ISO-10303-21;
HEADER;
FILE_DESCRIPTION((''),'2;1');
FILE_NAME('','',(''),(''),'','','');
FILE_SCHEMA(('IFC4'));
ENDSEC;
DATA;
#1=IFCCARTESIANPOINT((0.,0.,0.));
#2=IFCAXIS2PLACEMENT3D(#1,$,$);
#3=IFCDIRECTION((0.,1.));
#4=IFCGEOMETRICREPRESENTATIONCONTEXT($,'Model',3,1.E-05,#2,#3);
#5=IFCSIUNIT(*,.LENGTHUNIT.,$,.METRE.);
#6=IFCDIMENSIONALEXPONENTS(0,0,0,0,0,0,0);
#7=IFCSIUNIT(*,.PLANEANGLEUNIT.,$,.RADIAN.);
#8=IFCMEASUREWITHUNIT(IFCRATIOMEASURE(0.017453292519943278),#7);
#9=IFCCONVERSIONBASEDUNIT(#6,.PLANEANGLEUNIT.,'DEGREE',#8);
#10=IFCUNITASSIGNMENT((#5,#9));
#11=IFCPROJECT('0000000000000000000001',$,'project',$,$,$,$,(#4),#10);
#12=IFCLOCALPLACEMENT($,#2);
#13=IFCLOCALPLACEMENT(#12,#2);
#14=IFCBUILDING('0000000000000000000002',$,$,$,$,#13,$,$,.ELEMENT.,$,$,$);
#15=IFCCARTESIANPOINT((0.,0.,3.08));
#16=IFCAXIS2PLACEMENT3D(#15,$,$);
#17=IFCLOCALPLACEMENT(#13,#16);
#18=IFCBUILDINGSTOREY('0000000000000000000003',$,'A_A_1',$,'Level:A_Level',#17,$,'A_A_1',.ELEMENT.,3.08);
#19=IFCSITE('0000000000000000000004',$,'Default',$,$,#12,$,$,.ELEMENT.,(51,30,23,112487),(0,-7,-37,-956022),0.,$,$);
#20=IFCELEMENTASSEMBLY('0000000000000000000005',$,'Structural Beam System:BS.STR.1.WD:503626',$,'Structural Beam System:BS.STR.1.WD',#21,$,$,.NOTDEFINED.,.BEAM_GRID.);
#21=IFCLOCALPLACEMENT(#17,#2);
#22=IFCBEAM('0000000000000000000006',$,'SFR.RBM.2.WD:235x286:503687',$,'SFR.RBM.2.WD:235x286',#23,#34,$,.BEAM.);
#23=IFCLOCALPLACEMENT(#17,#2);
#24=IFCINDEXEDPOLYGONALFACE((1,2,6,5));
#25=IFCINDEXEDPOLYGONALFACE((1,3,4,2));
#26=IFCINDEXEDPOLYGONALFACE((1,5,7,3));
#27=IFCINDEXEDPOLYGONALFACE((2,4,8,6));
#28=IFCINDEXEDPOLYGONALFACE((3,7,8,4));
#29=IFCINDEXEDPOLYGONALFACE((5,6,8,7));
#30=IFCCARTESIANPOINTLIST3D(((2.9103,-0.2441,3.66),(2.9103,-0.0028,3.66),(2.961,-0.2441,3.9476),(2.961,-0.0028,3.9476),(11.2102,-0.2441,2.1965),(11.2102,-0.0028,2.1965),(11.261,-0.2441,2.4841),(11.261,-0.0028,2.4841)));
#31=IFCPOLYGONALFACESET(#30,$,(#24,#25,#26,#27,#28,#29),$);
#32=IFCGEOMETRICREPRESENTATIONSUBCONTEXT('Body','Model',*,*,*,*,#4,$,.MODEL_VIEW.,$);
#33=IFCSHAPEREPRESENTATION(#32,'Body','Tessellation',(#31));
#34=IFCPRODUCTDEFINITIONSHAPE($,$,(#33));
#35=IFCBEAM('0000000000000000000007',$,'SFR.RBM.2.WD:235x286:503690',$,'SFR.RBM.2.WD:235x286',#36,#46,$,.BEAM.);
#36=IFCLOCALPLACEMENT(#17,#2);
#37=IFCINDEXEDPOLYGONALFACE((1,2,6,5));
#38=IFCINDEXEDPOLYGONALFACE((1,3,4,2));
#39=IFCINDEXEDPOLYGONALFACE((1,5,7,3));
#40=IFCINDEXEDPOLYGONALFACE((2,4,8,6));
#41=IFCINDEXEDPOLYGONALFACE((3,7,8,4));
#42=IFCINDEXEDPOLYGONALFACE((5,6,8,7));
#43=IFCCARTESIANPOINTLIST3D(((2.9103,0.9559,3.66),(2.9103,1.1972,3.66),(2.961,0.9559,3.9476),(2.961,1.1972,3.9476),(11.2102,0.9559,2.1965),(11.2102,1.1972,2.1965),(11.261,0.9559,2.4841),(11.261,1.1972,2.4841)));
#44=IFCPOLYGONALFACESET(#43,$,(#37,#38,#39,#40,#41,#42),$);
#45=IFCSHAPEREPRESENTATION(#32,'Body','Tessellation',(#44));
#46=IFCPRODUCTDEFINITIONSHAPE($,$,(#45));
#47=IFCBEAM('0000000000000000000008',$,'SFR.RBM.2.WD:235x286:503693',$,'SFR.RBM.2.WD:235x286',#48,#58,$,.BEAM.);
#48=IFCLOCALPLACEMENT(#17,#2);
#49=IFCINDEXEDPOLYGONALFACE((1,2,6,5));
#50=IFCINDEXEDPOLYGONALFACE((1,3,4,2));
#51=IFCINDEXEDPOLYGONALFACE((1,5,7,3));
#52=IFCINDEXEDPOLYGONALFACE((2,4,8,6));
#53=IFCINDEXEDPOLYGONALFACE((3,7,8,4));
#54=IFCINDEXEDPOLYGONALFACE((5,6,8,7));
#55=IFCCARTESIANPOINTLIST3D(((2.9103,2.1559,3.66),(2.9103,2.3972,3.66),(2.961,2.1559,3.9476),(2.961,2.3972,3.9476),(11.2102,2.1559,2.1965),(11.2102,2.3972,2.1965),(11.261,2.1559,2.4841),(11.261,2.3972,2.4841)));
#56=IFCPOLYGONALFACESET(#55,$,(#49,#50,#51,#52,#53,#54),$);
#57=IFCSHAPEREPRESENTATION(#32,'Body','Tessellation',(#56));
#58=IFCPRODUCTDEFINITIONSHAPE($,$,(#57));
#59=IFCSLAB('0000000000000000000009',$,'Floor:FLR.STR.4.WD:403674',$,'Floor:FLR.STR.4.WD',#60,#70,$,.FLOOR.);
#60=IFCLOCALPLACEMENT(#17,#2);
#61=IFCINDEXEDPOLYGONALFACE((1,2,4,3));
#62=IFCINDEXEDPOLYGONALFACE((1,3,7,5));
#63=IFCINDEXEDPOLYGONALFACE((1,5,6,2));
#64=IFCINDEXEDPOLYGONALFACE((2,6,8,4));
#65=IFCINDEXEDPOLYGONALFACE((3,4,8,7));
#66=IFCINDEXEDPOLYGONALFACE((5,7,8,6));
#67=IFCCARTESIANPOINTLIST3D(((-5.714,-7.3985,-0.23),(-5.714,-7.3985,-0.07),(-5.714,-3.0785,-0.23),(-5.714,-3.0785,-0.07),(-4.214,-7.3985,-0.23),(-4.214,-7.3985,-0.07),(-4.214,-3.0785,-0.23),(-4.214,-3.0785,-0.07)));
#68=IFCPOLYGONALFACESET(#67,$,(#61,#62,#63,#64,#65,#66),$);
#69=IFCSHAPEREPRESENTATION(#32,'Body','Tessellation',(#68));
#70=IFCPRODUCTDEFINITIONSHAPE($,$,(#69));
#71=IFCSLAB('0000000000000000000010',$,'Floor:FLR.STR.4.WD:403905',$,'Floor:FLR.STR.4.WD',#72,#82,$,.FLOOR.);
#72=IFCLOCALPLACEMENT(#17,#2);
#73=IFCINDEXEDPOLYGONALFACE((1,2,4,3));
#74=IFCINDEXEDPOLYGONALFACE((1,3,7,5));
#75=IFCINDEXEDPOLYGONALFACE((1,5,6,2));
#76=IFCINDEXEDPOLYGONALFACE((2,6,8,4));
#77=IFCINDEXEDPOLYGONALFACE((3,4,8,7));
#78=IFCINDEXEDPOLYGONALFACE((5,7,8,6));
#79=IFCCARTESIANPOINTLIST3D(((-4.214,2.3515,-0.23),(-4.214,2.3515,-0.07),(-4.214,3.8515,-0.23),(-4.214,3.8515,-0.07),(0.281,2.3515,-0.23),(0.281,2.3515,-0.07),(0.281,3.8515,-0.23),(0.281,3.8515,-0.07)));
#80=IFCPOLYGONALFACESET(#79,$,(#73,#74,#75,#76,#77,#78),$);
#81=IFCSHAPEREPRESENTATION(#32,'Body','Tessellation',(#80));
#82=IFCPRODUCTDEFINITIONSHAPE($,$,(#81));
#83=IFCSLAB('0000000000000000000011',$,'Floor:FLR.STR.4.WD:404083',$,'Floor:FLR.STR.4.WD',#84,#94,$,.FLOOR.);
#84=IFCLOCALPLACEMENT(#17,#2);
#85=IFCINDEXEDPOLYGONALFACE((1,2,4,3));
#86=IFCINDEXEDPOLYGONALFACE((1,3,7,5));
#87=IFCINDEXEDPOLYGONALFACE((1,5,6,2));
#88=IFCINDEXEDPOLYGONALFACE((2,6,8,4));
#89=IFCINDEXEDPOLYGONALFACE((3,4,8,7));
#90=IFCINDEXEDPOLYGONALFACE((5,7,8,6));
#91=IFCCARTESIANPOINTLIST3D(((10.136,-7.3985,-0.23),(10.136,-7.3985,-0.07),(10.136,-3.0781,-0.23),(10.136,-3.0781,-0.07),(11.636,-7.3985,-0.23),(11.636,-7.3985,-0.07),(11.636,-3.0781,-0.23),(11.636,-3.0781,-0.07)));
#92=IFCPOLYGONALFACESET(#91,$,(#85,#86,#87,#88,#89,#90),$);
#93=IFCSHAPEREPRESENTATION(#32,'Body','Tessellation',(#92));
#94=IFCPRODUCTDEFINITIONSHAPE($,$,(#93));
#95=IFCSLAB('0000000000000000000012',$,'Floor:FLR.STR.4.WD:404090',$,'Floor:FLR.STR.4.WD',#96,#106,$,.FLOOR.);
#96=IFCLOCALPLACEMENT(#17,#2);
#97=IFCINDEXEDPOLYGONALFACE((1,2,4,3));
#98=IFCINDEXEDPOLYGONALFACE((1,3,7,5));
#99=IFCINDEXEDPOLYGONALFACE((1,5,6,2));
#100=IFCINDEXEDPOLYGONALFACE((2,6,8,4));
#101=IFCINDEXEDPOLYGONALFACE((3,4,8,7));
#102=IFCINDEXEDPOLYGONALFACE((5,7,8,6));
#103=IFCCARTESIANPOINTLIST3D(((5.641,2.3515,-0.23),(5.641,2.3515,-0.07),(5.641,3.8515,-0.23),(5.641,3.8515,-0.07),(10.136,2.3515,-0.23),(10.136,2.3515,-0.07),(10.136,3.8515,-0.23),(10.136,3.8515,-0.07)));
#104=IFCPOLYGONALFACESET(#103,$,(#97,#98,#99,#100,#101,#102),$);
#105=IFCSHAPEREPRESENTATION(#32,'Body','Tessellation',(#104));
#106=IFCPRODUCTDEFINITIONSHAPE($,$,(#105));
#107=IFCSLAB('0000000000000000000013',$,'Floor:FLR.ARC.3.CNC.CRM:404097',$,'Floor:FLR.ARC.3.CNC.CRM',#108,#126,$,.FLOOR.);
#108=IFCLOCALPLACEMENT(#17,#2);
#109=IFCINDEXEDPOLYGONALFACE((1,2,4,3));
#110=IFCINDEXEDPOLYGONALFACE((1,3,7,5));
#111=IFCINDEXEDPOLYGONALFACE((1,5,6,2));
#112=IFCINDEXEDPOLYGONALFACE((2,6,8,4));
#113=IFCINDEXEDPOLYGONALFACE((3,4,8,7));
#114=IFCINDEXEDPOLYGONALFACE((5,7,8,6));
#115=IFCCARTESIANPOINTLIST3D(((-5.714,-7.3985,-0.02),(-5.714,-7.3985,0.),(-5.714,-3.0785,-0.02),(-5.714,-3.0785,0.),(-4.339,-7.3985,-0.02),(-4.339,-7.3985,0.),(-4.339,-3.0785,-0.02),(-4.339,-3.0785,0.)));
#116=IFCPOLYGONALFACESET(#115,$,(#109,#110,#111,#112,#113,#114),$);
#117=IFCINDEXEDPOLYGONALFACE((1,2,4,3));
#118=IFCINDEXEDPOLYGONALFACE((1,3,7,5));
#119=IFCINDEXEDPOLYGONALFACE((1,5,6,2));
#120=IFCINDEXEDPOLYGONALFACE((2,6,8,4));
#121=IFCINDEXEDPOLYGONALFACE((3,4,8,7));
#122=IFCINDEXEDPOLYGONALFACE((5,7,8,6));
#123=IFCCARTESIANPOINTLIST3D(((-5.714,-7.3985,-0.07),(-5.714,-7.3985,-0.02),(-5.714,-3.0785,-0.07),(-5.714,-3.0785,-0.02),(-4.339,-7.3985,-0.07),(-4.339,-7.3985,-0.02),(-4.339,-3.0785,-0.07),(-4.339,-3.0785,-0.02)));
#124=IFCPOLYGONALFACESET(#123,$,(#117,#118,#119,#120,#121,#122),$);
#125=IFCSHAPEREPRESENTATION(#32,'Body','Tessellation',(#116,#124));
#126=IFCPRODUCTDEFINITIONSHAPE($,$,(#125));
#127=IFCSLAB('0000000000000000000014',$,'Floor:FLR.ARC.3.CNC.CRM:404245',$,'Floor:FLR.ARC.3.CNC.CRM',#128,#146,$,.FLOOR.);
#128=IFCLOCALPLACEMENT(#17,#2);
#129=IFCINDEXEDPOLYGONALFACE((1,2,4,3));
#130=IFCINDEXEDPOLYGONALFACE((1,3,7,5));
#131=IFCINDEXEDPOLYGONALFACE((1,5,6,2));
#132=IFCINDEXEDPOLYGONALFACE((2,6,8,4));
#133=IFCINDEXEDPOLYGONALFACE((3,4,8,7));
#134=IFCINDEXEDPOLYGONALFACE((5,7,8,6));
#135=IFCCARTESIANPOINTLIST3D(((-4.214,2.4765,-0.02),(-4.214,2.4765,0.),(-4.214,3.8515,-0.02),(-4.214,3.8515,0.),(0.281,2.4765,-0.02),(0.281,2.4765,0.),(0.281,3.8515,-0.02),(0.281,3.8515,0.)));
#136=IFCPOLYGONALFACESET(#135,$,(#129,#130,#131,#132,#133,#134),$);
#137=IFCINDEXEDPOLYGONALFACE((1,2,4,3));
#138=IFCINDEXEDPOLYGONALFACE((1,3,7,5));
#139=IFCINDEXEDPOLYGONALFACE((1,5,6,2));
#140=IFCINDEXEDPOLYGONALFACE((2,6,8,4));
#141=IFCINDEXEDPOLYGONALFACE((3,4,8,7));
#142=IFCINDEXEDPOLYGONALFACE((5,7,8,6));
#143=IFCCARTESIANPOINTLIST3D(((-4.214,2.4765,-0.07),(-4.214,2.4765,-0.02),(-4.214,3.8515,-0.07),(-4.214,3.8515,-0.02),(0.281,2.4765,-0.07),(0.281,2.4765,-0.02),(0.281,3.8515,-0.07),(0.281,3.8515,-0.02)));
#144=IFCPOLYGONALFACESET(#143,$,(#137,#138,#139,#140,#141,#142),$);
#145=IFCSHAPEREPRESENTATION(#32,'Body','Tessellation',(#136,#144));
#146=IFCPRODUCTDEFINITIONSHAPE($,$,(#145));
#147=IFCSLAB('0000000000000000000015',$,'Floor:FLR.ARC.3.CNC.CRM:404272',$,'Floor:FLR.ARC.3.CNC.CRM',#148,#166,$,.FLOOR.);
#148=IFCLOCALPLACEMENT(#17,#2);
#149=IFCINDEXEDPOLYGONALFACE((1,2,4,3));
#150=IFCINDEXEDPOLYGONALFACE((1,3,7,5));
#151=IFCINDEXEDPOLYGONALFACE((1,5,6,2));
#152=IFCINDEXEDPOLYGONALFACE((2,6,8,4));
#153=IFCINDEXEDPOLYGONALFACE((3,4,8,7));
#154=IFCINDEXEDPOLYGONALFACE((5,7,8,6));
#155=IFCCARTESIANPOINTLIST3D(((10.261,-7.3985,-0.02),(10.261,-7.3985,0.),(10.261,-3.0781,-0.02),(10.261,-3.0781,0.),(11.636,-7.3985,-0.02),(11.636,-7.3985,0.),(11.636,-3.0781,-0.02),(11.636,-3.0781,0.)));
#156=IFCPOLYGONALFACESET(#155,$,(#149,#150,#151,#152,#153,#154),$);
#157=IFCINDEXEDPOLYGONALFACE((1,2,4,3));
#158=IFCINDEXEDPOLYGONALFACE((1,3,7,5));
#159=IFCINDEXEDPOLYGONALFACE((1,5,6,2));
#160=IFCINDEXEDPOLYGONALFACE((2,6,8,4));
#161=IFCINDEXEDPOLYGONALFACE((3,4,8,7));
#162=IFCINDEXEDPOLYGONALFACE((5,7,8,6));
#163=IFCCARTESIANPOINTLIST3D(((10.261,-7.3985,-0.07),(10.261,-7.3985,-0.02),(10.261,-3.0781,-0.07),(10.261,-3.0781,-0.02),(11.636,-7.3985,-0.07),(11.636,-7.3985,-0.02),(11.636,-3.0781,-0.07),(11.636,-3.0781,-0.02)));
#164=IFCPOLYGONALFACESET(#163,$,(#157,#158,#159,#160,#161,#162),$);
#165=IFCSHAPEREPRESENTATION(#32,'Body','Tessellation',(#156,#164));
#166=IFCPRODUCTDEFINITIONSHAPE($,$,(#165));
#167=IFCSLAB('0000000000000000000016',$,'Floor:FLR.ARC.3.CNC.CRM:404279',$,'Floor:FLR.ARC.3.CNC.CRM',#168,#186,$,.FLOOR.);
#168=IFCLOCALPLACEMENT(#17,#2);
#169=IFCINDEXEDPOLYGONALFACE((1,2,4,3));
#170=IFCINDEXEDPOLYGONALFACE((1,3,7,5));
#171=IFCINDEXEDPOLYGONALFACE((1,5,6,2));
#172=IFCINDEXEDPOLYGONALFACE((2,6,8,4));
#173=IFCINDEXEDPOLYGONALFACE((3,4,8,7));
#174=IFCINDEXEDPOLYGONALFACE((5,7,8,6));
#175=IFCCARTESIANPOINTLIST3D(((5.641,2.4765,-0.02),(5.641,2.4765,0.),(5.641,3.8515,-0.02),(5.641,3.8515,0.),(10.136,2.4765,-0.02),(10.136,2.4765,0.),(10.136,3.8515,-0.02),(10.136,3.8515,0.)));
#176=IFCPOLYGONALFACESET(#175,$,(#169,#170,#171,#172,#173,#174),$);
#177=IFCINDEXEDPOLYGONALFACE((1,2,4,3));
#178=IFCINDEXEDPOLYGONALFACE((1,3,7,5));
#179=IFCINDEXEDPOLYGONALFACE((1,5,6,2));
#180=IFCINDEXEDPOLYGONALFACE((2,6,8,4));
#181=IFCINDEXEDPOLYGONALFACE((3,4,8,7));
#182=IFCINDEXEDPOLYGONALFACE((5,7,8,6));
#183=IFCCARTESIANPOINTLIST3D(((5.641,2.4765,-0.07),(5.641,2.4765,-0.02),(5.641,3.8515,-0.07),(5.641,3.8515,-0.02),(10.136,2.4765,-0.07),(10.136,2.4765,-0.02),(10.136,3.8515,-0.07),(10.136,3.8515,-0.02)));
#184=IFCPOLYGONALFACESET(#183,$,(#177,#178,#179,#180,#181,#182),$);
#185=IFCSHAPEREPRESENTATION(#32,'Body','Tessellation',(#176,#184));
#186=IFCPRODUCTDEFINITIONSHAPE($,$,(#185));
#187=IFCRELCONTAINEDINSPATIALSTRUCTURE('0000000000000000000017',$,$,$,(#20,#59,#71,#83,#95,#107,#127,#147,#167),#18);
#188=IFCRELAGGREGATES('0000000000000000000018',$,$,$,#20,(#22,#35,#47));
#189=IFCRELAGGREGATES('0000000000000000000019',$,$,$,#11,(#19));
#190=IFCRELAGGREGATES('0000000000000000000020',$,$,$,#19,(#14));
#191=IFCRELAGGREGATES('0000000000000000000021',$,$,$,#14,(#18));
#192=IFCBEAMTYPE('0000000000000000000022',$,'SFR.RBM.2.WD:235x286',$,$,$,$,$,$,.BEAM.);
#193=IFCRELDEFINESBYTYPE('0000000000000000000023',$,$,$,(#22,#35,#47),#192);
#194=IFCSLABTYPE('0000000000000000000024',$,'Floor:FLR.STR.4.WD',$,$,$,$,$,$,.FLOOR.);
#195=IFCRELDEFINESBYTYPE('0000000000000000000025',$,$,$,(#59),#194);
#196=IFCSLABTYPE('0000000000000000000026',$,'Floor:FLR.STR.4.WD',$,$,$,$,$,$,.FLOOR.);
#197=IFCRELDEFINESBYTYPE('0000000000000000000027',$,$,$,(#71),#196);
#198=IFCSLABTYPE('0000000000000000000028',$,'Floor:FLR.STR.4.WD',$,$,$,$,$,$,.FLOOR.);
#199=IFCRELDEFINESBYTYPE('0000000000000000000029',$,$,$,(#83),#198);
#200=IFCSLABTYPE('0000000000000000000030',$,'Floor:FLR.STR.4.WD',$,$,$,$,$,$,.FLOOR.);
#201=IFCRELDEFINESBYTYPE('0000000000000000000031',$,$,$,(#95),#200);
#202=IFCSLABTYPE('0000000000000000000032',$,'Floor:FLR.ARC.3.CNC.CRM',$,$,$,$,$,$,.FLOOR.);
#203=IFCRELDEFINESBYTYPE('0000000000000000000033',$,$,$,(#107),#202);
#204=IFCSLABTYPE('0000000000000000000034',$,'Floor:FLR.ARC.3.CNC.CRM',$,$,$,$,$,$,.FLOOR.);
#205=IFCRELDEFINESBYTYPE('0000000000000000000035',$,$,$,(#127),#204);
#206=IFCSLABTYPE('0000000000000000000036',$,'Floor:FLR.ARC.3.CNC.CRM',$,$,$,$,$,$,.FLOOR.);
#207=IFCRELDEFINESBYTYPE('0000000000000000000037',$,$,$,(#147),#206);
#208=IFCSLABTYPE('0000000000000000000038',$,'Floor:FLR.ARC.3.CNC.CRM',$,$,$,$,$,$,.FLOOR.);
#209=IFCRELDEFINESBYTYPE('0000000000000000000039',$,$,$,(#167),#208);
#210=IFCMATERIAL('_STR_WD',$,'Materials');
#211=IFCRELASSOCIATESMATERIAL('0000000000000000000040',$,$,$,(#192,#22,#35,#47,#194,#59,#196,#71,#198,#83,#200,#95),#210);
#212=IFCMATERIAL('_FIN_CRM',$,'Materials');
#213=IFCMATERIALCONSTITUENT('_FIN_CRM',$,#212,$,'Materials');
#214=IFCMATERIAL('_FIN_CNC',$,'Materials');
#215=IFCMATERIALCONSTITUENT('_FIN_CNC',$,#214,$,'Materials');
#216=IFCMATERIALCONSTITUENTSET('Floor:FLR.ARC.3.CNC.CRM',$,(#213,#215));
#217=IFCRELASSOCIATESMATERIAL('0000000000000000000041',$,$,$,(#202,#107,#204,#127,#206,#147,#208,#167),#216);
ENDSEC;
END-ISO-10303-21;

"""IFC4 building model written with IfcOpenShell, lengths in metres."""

from ifc_helpers import new_model, entity, si_unit, converted_unit, direction, frame, origin, place, context, subcontext, project, spatial, indexed_curve, outline, extrude, source, transform, mapped, material, constituent, constituent_set, type_object, type_shapes, element, aggregate, save


model = new_model("IFC4")

# Units and contexts
model_context = context("Model", 3, precision=1e-05, world=origin(), true_north=direction((0.0, 1.0)))
body_context = subcontext(model_context, "Body", "Model", "MODEL_VIEW")
ifc_project = project(units=[si_unit("LENGTHUNIT", "METRE"), converted_unit("PLANEANGLEUNIT", "DEGREE", entity("IfcRatioMeasure", 0.017453292519943278), si_unit("PLANEANGLEUNIT", "RADIAN"), dimensions=[0, 0, 0, 0, 0, 0, 0])], contexts=[model_context])

# Site, building, storey
site_placement = place(None, origin())
site = spatial("IfcSite", under=ifc_project, at=site_placement, Name="Default", CompositionType="ELEMENT", RefLatitude=(51, 30, 23, 112487), RefLongitude=(0, -7, -37, -956022), RefElevation=0.0)
building_placement = place(site_placement, origin())
building = spatial("IfcBuilding", under=site, at=building_placement, CompositionType="ELEMENT")
storey_placement = place(building_placement, frame((0.0, 0.0, 3.08)))
storey = spatial("IfcBuildingStorey", under=building, at=storey_placement, Name="A_A_1", ObjectType="Level:A_Level", LongName="A_A_1", CompositionType="ELEMENT", Elevation=3.08)

# Element assembly, beams
ifc_material_1 = material(Name="_STR_WD", Category="Materials")
beam_type = type_object("IfcBeamType", Name="SFR.RBM.2.WD:235x286", PredefinedType="BEAM", material=ifc_material_1)
shared_shape = source(origin(), body_context, "Body", "SweptSolid", [
    extrude(outline(indexed_curve([(-0.146, -0.1207), (0.146, -0.1207), (0.146, 0.1207), (-0.146, 0.1207), (-0.146, -0.1207)], self_intersect=False)), frame((-4.214, 0.0, 0.0), z_axis=(1.0, 0.0, 0.0), x_axis=(0.0, 0.0, -1.0)), (0.0, 0.0, 1.0), 8.428),
])
type_shapes(beam_type, [shared_shape])
assembly_1_placement = place(storey_placement, origin())
assembly_1 = element("IfcElementAssembly", 1, at=assembly_1_placement, inside=storey, Name="Structural Beam System:BS.STR.1.WD:503626", ObjectType="Structural Beam System:BS.STR.1.WD", AssemblyPlace="NOTDEFINED", PredefinedType="BEAM_GRID")
beam_1_placement = place(assembly_1_placement, frame((7.0856, -0.1235, 3.072), z_axis=(0.173648, 0.0, 0.984808), x_axis=(0.984808, 0.0, -0.173648)))
beam_1 = element("IfcBeam", 2, at=beam_1_placement, type_object=beam_type, material=ifc_material_1, Name="SFR.RBM.2.WD:235x286:503687", ObjectType="SFR.RBM.2.WD:235x286", PredefinedType="BEAM", context=body_context, shape_type="MappedRepresentation", body=[
    mapped(shared_shape, transform((0.0, 0.0, 0.0), scale=1.0)),
])
beam_2_placement = place(assembly_1_placement, frame((7.0856, 1.0765, 3.072), z_axis=(0.173648, 0.0, 0.984808), x_axis=(0.984808, 0.0, -0.173648)))
beam_2 = element("IfcBeam", 3, at=beam_2_placement, type_object=beam_type, material=ifc_material_1, Name="SFR.RBM.2.WD:235x286:503690", ObjectType="SFR.RBM.2.WD:235x286", PredefinedType="BEAM", context=body_context, shape_type="MappedRepresentation", body=[
    mapped(shared_shape, transform((0.0, 0.0, 0.0), scale=1.0)),
])
beam_3_placement = place(assembly_1_placement, frame((7.0856, 2.2765, 3.072), z_axis=(0.173648, 0.0, 0.984808), x_axis=(0.984808, 0.0, -0.173648)))
beam_3 = element("IfcBeam", 4, at=beam_3_placement, type_object=beam_type, material=ifc_material_1, Name="SFR.RBM.2.WD:235x286:503693", ObjectType="SFR.RBM.2.WD:235x286", PredefinedType="BEAM", context=body_context, shape_type="MappedRepresentation", body=[
    mapped(shared_shape, transform((0.0, 0.0, 0.0), scale=1.0)),
])
aggregate(assembly_1, [beam_1, beam_2, beam_3])

# Slabs
ifc_material_2 = material(Name="_FIN_CNC", Category="Materials")
slab_type_1 = type_object("IfcSlabType", Name="Floor:FLR.STR.4.WD", PredefinedType="FLOOR", material=ifc_material_1)
slab_1_placement = place(storey_placement, origin())
element("IfcSlab", 5, at=slab_1_placement, inside=storey, type_object=slab_type_1, material=ifc_material_1, Name="Floor:FLR.STR.4.WD:403674", ObjectType="Floor:FLR.STR.4.WD", PredefinedType="FLOOR", context=body_context, shape_type="SweptSolid", body=[
    extrude(outline(indexed_curve([(-2.16, -0.75), (2.16, -0.75), (2.16, 0.75), (-2.16, 0.75), (-2.16, -0.75)], self_intersect=False)), frame((-4.964, -5.2385, -0.07), z_axis=(0.0, 0.0, -1.0), x_axis=(0.0, 1.0, 0.0)), (0.0, 0.0, 1.0), 0.16),
])
slab_type_2 = type_object("IfcSlabType", Name="Floor:FLR.STR.4.WD", PredefinedType="FLOOR", material=ifc_material_1)
slab_2_placement = place(storey_placement, origin())
element("IfcSlab", 6, at=slab_2_placement, inside=storey, type_object=slab_type_2, material=ifc_material_1, Name="Floor:FLR.STR.4.WD:403905", ObjectType="Floor:FLR.STR.4.WD", PredefinedType="FLOOR", context=body_context, shape_type="SweptSolid", body=[
    extrude(outline(indexed_curve([(-0.75, -2.2475), (0.75, -2.2475), (0.75, 2.2475), (-0.75, 2.2475), (-0.75, -2.2475)], self_intersect=False)), frame((-1.9665, 3.1015, -0.07), z_axis=(0.0, 0.0, -1.0), x_axis=(0.0, 1.0, 0.0)), (0.0, 0.0, 1.0), 0.16),
])
slab_type_3 = type_object("IfcSlabType", Name="Floor:FLR.STR.4.WD", PredefinedType="FLOOR", material=ifc_material_1)
slab_3_placement = place(storey_placement, origin())
element("IfcSlab", 7, at=slab_3_placement, inside=storey, type_object=slab_type_3, material=ifc_material_1, Name="Floor:FLR.STR.4.WD:404083", ObjectType="Floor:FLR.STR.4.WD", PredefinedType="FLOOR", context=body_context, shape_type="SweptSolid", body=[
    extrude(outline(indexed_curve([(-2.1602, -0.75), (2.1602, -0.75), (2.1602, 0.75), (-2.1602, 0.75), (-2.1602, -0.75)], self_intersect=False)), frame((10.886, -5.2383, -0.07), z_axis=(0.0, 0.0, -1.0), x_axis=(0.0, 1.0, 0.0)), (0.0, 0.0, 1.0), 0.16),
])
slab_type_4 = type_object("IfcSlabType", Name="Floor:FLR.STR.4.WD", PredefinedType="FLOOR", material=ifc_material_1)
slab_4_placement = place(storey_placement, origin())
element("IfcSlab", 8, at=slab_4_placement, inside=storey, type_object=slab_type_4, material=ifc_material_1, Name="Floor:FLR.STR.4.WD:404090", ObjectType="Floor:FLR.STR.4.WD", PredefinedType="FLOOR", context=body_context, shape_type="SweptSolid", body=[
    extrude(outline(indexed_curve([(-0.75, -2.2475), (0.75, -2.2475), (0.75, 2.2475), (-0.75, 2.2475), (-0.75, -2.2475)], self_intersect=False)), frame((7.8885, 3.1015, -0.07), z_axis=(0.0, 0.0, -1.0), x_axis=(0.0, 1.0, 0.0)), (0.0, 0.0, 1.0), 0.16),
])
ifc_material_3 = material(Name="_FIN_CRM", Category="Materials")
ifc_constituent_1 = constituent(ifc_material_3, Name="_FIN_CRM", Category="Materials")
ifc_constituent_2 = constituent(ifc_material_2, Name="_FIN_CNC", Category="Materials")
ifc_constituent_set_1 = constituent_set(constituents=[ifc_constituent_1, ifc_constituent_2], Name="Floor:FLR.ARC.3.CNC.CRM")
slab_type_5 = type_object("IfcSlabType", Name="Floor:FLR.ARC.3.CNC.CRM", PredefinedType="FLOOR", material=ifc_constituent_set_1)
slab_5_placement = place(storey_placement, origin())
element("IfcSlab", 9, at=slab_5_placement, inside=storey, type_object=slab_type_5, material=ifc_constituent_set_1, Name="Floor:FLR.ARC.3.CNC.CRM:404097", ObjectType="Floor:FLR.ARC.3.CNC.CRM", PredefinedType="FLOOR", context=body_context, shape_type="SweptSolid", body=[
    extrude(outline(indexed_curve([(-2.16, -0.6875), (2.16, -0.6875), (2.16, 0.6875), (-2.16, 0.6875), (-2.16, -0.6875)], self_intersect=False)), frame((-5.0265, -5.2385, -0.02), z_axis=(0.0, 0.0, 1.0), x_axis=(0.0, -1.0, 0.0)), (0.0, 0.0, 1.0), 0.02),
    extrude(outline(indexed_curve([(-2.16, -0.6875), (2.16, -0.6875), (2.16, 0.6875), (-2.16, 0.6875), (-2.16, -0.6875)], self_intersect=False)), frame((-5.0265, -5.2385, -0.07), z_axis=(0.0, 0.0, 1.0), x_axis=(0.0, -1.0, 0.0)), (0.0, 0.0, 1.0), 0.05),
])
slab_type_6 = type_object("IfcSlabType", Name="Floor:FLR.ARC.3.CNC.CRM", PredefinedType="FLOOR", material=ifc_constituent_set_1)
slab_6_placement = place(storey_placement, origin())
element("IfcSlab", 10, at=slab_6_placement, inside=storey, type_object=slab_type_6, material=ifc_constituent_set_1, Name="Floor:FLR.ARC.3.CNC.CRM:404245", ObjectType="Floor:FLR.ARC.3.CNC.CRM", PredefinedType="FLOOR", context=body_context, shape_type="SweptSolid", body=[
    extrude(outline(indexed_curve([(-0.6875, -2.2475), (0.6875, -2.2475), (0.6875, 2.2475), (-0.6875, 2.2475), (-0.6875, -2.2475)], self_intersect=False)), frame((-1.9665, 3.164, -0.02), z_axis=(0.0, 0.0, 1.0), x_axis=(0.0, -1.0, 0.0)), (0.0, 0.0, 1.0), 0.02),
    extrude(outline(indexed_curve([(-0.6875, -2.2475), (0.6875, -2.2475), (0.6875, 2.2475), (-0.6875, 2.2475), (-0.6875, -2.2475)], self_intersect=False)), frame((-1.9665, 3.164, -0.07), z_axis=(0.0, 0.0, 1.0), x_axis=(0.0, -1.0, 0.0)), (0.0, 0.0, 1.0), 0.05),
])
slab_type_7 = type_object("IfcSlabType", Name="Floor:FLR.ARC.3.CNC.CRM", PredefinedType="FLOOR", material=ifc_constituent_set_1)
slab_7_placement = place(storey_placement, origin())
element("IfcSlab", 11, at=slab_7_placement, inside=storey, type_object=slab_type_7, material=ifc_constituent_set_1, Name="Floor:FLR.ARC.3.CNC.CRM:404272", ObjectType="Floor:FLR.ARC.3.CNC.CRM", PredefinedType="FLOOR", context=body_context, shape_type="SweptSolid", body=[
    extrude(outline(indexed_curve([(-2.1602, -0.6875), (2.1602, -0.6875), (2.1602, 0.6875), (-2.1602, 0.6875), (-2.1602, -0.6875)], self_intersect=False)), frame((10.9485, -5.2383, -0.02), z_axis=(0.0, 0.0, 1.0), x_axis=(0.0, -1.0, 0.0)), (0.0, 0.0, 1.0), 0.02),
    extrude(outline(indexed_curve([(-0.6875, -2.1602), (0.6875, -2.1602), (0.6875, 2.1602), (-0.6875, 2.1602), (-0.6875, -2.1602)], self_intersect=False)), frame((10.9485, -5.2383, -0.07), z_axis=(0.0, 0.0, 1.0), x_axis=(-1.0, 0.0, 0.0)), (0.0, 0.0, 1.0), 0.05),
])
slab_type_8 = type_object("IfcSlabType", Name="Floor:FLR.ARC.3.CNC.CRM", PredefinedType="FLOOR", material=ifc_constituent_set_1)
slab_8_placement = place(storey_placement, origin())
element("IfcSlab", 12, at=slab_8_placement, inside=storey, type_object=slab_type_8, material=ifc_constituent_set_1, Name="Floor:FLR.ARC.3.CNC.CRM:404279", ObjectType="Floor:FLR.ARC.3.CNC.CRM", PredefinedType="FLOOR", context=body_context, shape_type="SweptSolid", body=[
    extrude(outline(indexed_curve([(-0.6875, -2.2475), (0.6875, -2.2475), (0.6875, 2.2475), (-0.6875, 2.2475), (-0.6875, -2.2475)], self_intersect=False)), frame((7.8885, 3.164, -0.02), z_axis=(0.0, 0.0, 1.0), x_axis=(0.0, -1.0, 0.0)), (0.0, 0.0, 1.0), 0.02),
    extrude(outline(indexed_curve([(-2.2475, -0.6875), (2.2475, -0.6875), (2.2475, 0.6875), (-2.2475, 0.6875), (-2.2475, -0.6875)], self_intersect=False)), frame((7.8885, 3.164, -0.07), z_axis=(0.0, 0.0, 1.0), x_axis=(-1.0, 0.0, 0.0)), (0.0, 0.0, 1.0), 0.05),
])

save(model, "model.ifc")
